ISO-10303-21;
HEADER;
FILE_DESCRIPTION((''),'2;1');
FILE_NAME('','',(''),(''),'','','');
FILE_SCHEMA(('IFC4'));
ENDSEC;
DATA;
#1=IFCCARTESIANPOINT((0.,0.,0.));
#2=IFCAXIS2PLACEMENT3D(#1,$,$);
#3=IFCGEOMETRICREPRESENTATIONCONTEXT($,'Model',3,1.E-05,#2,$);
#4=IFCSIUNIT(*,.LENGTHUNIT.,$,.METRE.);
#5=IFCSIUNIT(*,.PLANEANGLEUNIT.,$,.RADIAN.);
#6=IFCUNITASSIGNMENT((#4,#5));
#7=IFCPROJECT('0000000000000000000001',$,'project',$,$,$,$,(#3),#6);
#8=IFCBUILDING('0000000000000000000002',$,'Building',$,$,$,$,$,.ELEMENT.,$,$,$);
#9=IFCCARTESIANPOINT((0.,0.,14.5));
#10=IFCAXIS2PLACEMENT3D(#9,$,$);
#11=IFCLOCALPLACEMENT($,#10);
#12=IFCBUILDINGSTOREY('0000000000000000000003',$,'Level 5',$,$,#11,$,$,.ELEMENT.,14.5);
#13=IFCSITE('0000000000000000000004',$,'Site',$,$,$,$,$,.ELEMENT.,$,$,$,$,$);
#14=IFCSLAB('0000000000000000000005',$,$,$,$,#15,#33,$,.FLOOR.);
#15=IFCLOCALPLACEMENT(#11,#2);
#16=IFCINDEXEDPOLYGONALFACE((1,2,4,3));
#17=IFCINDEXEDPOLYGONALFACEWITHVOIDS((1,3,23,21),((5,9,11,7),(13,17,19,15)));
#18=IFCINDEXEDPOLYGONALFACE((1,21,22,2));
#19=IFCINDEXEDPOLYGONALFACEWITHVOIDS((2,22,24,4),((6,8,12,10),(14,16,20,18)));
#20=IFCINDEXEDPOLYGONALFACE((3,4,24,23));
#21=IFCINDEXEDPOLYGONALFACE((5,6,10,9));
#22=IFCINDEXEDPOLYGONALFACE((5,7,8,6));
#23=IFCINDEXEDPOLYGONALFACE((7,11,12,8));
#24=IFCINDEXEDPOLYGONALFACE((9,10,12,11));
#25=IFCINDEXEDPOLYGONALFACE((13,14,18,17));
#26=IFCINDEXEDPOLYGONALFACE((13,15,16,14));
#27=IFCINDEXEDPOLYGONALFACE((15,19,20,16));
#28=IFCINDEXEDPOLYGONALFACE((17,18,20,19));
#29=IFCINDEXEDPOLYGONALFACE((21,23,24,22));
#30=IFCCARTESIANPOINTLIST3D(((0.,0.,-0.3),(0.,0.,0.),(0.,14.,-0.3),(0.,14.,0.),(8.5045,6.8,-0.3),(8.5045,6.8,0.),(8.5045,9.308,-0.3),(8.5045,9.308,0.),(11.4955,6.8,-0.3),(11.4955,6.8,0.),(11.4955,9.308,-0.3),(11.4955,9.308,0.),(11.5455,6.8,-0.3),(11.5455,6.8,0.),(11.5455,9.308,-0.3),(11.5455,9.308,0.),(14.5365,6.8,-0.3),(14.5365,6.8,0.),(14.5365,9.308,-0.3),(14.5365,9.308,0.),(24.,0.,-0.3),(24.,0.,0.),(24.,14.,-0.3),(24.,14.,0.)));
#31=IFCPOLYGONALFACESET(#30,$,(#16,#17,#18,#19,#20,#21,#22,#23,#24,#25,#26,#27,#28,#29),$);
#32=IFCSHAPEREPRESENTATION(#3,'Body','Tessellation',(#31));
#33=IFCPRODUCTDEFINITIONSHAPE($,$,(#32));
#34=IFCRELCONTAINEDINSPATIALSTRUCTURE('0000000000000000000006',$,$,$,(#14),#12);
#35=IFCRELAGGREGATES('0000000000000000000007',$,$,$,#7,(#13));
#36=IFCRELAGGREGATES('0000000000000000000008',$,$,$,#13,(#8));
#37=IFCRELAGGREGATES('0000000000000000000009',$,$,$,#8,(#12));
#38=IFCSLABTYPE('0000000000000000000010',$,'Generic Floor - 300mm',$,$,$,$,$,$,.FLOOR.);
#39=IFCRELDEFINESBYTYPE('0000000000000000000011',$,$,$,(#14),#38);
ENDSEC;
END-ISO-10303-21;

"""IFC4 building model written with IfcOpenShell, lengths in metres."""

from ifc_helpers import new_model, si_unit, frame, origin, place, context, project, spatial, polyline, outline, extrude, type_object, element, save


model = new_model("IFC4")

# Units and contexts
model_context = context("Model", 3, precision=1e-05, world=origin())
ifc_project = project(units=[si_unit("LENGTHUNIT", "METRE"), si_unit("PLANEANGLEUNIT", "RADIAN")], contexts=[model_context])

# Site, building, storey
site = spatial("IfcSite", under=ifc_project, Name="Site", CompositionType="ELEMENT")
building = spatial("IfcBuilding", under=site, Name="Building", CompositionType="ELEMENT")
storey_placement = place(None, frame((0.0, 0.0, 14.5)))
storey = spatial("IfcBuildingStorey", under=building, at=storey_placement, Name="Level 5", CompositionType="ELEMENT", Elevation=14.5)

# Slab, openings
slab_type = type_object("IfcSlabType", Name="Generic Floor - 300mm", PredefinedType="FLOOR")
slab_placement = place(None, frame((0.0, 0.0, 14.5)))
slab = element("IfcSlab", 1, at=slab_placement, inside=storey, type_object=slab_type, PredefinedType="FLOOR", context=model_context, shape_type="SweptSolid", body=[
    extrude(outline(polyline([(0.0, 0.0), (24.0, 0.0), (24.0, 14.0), (0.0, 14.0), (0.0, 0.0)])), origin(), (0.0, 0.0, -1.0), 0.3),
])
opening_1_placement = place(None, frame((0.0, 0.0, 14.501)))
element("IfcOpeningElement", 2, at=opening_1_placement, cuts=slab, PredefinedType="OPENING", context=model_context, shape_type="SweptSolid", body=[
    extrude(outline(polyline([(8.5045, 6.8), (11.4955, 6.8), (11.4955, 9.308), (8.5045, 9.308), (8.5045, 6.8)])), origin(), (0.0, 0.0, -1.0), 0.302),
])
opening_2_placement = place(None, frame((0.0, 0.0, 14.501)))
element("IfcOpeningElement", 3, at=opening_2_placement, cuts=slab, PredefinedType="OPENING", context=model_context, shape_type="SweptSolid", body=[
    extrude(outline(polyline([(11.5455, 6.8), (14.5365, 6.8), (14.5365, 9.308), (11.5455, 9.308), (11.5455, 6.8)])), origin(), (0.0, 0.0, -1.0), 0.302),
])

save(model, "model.ifc")
